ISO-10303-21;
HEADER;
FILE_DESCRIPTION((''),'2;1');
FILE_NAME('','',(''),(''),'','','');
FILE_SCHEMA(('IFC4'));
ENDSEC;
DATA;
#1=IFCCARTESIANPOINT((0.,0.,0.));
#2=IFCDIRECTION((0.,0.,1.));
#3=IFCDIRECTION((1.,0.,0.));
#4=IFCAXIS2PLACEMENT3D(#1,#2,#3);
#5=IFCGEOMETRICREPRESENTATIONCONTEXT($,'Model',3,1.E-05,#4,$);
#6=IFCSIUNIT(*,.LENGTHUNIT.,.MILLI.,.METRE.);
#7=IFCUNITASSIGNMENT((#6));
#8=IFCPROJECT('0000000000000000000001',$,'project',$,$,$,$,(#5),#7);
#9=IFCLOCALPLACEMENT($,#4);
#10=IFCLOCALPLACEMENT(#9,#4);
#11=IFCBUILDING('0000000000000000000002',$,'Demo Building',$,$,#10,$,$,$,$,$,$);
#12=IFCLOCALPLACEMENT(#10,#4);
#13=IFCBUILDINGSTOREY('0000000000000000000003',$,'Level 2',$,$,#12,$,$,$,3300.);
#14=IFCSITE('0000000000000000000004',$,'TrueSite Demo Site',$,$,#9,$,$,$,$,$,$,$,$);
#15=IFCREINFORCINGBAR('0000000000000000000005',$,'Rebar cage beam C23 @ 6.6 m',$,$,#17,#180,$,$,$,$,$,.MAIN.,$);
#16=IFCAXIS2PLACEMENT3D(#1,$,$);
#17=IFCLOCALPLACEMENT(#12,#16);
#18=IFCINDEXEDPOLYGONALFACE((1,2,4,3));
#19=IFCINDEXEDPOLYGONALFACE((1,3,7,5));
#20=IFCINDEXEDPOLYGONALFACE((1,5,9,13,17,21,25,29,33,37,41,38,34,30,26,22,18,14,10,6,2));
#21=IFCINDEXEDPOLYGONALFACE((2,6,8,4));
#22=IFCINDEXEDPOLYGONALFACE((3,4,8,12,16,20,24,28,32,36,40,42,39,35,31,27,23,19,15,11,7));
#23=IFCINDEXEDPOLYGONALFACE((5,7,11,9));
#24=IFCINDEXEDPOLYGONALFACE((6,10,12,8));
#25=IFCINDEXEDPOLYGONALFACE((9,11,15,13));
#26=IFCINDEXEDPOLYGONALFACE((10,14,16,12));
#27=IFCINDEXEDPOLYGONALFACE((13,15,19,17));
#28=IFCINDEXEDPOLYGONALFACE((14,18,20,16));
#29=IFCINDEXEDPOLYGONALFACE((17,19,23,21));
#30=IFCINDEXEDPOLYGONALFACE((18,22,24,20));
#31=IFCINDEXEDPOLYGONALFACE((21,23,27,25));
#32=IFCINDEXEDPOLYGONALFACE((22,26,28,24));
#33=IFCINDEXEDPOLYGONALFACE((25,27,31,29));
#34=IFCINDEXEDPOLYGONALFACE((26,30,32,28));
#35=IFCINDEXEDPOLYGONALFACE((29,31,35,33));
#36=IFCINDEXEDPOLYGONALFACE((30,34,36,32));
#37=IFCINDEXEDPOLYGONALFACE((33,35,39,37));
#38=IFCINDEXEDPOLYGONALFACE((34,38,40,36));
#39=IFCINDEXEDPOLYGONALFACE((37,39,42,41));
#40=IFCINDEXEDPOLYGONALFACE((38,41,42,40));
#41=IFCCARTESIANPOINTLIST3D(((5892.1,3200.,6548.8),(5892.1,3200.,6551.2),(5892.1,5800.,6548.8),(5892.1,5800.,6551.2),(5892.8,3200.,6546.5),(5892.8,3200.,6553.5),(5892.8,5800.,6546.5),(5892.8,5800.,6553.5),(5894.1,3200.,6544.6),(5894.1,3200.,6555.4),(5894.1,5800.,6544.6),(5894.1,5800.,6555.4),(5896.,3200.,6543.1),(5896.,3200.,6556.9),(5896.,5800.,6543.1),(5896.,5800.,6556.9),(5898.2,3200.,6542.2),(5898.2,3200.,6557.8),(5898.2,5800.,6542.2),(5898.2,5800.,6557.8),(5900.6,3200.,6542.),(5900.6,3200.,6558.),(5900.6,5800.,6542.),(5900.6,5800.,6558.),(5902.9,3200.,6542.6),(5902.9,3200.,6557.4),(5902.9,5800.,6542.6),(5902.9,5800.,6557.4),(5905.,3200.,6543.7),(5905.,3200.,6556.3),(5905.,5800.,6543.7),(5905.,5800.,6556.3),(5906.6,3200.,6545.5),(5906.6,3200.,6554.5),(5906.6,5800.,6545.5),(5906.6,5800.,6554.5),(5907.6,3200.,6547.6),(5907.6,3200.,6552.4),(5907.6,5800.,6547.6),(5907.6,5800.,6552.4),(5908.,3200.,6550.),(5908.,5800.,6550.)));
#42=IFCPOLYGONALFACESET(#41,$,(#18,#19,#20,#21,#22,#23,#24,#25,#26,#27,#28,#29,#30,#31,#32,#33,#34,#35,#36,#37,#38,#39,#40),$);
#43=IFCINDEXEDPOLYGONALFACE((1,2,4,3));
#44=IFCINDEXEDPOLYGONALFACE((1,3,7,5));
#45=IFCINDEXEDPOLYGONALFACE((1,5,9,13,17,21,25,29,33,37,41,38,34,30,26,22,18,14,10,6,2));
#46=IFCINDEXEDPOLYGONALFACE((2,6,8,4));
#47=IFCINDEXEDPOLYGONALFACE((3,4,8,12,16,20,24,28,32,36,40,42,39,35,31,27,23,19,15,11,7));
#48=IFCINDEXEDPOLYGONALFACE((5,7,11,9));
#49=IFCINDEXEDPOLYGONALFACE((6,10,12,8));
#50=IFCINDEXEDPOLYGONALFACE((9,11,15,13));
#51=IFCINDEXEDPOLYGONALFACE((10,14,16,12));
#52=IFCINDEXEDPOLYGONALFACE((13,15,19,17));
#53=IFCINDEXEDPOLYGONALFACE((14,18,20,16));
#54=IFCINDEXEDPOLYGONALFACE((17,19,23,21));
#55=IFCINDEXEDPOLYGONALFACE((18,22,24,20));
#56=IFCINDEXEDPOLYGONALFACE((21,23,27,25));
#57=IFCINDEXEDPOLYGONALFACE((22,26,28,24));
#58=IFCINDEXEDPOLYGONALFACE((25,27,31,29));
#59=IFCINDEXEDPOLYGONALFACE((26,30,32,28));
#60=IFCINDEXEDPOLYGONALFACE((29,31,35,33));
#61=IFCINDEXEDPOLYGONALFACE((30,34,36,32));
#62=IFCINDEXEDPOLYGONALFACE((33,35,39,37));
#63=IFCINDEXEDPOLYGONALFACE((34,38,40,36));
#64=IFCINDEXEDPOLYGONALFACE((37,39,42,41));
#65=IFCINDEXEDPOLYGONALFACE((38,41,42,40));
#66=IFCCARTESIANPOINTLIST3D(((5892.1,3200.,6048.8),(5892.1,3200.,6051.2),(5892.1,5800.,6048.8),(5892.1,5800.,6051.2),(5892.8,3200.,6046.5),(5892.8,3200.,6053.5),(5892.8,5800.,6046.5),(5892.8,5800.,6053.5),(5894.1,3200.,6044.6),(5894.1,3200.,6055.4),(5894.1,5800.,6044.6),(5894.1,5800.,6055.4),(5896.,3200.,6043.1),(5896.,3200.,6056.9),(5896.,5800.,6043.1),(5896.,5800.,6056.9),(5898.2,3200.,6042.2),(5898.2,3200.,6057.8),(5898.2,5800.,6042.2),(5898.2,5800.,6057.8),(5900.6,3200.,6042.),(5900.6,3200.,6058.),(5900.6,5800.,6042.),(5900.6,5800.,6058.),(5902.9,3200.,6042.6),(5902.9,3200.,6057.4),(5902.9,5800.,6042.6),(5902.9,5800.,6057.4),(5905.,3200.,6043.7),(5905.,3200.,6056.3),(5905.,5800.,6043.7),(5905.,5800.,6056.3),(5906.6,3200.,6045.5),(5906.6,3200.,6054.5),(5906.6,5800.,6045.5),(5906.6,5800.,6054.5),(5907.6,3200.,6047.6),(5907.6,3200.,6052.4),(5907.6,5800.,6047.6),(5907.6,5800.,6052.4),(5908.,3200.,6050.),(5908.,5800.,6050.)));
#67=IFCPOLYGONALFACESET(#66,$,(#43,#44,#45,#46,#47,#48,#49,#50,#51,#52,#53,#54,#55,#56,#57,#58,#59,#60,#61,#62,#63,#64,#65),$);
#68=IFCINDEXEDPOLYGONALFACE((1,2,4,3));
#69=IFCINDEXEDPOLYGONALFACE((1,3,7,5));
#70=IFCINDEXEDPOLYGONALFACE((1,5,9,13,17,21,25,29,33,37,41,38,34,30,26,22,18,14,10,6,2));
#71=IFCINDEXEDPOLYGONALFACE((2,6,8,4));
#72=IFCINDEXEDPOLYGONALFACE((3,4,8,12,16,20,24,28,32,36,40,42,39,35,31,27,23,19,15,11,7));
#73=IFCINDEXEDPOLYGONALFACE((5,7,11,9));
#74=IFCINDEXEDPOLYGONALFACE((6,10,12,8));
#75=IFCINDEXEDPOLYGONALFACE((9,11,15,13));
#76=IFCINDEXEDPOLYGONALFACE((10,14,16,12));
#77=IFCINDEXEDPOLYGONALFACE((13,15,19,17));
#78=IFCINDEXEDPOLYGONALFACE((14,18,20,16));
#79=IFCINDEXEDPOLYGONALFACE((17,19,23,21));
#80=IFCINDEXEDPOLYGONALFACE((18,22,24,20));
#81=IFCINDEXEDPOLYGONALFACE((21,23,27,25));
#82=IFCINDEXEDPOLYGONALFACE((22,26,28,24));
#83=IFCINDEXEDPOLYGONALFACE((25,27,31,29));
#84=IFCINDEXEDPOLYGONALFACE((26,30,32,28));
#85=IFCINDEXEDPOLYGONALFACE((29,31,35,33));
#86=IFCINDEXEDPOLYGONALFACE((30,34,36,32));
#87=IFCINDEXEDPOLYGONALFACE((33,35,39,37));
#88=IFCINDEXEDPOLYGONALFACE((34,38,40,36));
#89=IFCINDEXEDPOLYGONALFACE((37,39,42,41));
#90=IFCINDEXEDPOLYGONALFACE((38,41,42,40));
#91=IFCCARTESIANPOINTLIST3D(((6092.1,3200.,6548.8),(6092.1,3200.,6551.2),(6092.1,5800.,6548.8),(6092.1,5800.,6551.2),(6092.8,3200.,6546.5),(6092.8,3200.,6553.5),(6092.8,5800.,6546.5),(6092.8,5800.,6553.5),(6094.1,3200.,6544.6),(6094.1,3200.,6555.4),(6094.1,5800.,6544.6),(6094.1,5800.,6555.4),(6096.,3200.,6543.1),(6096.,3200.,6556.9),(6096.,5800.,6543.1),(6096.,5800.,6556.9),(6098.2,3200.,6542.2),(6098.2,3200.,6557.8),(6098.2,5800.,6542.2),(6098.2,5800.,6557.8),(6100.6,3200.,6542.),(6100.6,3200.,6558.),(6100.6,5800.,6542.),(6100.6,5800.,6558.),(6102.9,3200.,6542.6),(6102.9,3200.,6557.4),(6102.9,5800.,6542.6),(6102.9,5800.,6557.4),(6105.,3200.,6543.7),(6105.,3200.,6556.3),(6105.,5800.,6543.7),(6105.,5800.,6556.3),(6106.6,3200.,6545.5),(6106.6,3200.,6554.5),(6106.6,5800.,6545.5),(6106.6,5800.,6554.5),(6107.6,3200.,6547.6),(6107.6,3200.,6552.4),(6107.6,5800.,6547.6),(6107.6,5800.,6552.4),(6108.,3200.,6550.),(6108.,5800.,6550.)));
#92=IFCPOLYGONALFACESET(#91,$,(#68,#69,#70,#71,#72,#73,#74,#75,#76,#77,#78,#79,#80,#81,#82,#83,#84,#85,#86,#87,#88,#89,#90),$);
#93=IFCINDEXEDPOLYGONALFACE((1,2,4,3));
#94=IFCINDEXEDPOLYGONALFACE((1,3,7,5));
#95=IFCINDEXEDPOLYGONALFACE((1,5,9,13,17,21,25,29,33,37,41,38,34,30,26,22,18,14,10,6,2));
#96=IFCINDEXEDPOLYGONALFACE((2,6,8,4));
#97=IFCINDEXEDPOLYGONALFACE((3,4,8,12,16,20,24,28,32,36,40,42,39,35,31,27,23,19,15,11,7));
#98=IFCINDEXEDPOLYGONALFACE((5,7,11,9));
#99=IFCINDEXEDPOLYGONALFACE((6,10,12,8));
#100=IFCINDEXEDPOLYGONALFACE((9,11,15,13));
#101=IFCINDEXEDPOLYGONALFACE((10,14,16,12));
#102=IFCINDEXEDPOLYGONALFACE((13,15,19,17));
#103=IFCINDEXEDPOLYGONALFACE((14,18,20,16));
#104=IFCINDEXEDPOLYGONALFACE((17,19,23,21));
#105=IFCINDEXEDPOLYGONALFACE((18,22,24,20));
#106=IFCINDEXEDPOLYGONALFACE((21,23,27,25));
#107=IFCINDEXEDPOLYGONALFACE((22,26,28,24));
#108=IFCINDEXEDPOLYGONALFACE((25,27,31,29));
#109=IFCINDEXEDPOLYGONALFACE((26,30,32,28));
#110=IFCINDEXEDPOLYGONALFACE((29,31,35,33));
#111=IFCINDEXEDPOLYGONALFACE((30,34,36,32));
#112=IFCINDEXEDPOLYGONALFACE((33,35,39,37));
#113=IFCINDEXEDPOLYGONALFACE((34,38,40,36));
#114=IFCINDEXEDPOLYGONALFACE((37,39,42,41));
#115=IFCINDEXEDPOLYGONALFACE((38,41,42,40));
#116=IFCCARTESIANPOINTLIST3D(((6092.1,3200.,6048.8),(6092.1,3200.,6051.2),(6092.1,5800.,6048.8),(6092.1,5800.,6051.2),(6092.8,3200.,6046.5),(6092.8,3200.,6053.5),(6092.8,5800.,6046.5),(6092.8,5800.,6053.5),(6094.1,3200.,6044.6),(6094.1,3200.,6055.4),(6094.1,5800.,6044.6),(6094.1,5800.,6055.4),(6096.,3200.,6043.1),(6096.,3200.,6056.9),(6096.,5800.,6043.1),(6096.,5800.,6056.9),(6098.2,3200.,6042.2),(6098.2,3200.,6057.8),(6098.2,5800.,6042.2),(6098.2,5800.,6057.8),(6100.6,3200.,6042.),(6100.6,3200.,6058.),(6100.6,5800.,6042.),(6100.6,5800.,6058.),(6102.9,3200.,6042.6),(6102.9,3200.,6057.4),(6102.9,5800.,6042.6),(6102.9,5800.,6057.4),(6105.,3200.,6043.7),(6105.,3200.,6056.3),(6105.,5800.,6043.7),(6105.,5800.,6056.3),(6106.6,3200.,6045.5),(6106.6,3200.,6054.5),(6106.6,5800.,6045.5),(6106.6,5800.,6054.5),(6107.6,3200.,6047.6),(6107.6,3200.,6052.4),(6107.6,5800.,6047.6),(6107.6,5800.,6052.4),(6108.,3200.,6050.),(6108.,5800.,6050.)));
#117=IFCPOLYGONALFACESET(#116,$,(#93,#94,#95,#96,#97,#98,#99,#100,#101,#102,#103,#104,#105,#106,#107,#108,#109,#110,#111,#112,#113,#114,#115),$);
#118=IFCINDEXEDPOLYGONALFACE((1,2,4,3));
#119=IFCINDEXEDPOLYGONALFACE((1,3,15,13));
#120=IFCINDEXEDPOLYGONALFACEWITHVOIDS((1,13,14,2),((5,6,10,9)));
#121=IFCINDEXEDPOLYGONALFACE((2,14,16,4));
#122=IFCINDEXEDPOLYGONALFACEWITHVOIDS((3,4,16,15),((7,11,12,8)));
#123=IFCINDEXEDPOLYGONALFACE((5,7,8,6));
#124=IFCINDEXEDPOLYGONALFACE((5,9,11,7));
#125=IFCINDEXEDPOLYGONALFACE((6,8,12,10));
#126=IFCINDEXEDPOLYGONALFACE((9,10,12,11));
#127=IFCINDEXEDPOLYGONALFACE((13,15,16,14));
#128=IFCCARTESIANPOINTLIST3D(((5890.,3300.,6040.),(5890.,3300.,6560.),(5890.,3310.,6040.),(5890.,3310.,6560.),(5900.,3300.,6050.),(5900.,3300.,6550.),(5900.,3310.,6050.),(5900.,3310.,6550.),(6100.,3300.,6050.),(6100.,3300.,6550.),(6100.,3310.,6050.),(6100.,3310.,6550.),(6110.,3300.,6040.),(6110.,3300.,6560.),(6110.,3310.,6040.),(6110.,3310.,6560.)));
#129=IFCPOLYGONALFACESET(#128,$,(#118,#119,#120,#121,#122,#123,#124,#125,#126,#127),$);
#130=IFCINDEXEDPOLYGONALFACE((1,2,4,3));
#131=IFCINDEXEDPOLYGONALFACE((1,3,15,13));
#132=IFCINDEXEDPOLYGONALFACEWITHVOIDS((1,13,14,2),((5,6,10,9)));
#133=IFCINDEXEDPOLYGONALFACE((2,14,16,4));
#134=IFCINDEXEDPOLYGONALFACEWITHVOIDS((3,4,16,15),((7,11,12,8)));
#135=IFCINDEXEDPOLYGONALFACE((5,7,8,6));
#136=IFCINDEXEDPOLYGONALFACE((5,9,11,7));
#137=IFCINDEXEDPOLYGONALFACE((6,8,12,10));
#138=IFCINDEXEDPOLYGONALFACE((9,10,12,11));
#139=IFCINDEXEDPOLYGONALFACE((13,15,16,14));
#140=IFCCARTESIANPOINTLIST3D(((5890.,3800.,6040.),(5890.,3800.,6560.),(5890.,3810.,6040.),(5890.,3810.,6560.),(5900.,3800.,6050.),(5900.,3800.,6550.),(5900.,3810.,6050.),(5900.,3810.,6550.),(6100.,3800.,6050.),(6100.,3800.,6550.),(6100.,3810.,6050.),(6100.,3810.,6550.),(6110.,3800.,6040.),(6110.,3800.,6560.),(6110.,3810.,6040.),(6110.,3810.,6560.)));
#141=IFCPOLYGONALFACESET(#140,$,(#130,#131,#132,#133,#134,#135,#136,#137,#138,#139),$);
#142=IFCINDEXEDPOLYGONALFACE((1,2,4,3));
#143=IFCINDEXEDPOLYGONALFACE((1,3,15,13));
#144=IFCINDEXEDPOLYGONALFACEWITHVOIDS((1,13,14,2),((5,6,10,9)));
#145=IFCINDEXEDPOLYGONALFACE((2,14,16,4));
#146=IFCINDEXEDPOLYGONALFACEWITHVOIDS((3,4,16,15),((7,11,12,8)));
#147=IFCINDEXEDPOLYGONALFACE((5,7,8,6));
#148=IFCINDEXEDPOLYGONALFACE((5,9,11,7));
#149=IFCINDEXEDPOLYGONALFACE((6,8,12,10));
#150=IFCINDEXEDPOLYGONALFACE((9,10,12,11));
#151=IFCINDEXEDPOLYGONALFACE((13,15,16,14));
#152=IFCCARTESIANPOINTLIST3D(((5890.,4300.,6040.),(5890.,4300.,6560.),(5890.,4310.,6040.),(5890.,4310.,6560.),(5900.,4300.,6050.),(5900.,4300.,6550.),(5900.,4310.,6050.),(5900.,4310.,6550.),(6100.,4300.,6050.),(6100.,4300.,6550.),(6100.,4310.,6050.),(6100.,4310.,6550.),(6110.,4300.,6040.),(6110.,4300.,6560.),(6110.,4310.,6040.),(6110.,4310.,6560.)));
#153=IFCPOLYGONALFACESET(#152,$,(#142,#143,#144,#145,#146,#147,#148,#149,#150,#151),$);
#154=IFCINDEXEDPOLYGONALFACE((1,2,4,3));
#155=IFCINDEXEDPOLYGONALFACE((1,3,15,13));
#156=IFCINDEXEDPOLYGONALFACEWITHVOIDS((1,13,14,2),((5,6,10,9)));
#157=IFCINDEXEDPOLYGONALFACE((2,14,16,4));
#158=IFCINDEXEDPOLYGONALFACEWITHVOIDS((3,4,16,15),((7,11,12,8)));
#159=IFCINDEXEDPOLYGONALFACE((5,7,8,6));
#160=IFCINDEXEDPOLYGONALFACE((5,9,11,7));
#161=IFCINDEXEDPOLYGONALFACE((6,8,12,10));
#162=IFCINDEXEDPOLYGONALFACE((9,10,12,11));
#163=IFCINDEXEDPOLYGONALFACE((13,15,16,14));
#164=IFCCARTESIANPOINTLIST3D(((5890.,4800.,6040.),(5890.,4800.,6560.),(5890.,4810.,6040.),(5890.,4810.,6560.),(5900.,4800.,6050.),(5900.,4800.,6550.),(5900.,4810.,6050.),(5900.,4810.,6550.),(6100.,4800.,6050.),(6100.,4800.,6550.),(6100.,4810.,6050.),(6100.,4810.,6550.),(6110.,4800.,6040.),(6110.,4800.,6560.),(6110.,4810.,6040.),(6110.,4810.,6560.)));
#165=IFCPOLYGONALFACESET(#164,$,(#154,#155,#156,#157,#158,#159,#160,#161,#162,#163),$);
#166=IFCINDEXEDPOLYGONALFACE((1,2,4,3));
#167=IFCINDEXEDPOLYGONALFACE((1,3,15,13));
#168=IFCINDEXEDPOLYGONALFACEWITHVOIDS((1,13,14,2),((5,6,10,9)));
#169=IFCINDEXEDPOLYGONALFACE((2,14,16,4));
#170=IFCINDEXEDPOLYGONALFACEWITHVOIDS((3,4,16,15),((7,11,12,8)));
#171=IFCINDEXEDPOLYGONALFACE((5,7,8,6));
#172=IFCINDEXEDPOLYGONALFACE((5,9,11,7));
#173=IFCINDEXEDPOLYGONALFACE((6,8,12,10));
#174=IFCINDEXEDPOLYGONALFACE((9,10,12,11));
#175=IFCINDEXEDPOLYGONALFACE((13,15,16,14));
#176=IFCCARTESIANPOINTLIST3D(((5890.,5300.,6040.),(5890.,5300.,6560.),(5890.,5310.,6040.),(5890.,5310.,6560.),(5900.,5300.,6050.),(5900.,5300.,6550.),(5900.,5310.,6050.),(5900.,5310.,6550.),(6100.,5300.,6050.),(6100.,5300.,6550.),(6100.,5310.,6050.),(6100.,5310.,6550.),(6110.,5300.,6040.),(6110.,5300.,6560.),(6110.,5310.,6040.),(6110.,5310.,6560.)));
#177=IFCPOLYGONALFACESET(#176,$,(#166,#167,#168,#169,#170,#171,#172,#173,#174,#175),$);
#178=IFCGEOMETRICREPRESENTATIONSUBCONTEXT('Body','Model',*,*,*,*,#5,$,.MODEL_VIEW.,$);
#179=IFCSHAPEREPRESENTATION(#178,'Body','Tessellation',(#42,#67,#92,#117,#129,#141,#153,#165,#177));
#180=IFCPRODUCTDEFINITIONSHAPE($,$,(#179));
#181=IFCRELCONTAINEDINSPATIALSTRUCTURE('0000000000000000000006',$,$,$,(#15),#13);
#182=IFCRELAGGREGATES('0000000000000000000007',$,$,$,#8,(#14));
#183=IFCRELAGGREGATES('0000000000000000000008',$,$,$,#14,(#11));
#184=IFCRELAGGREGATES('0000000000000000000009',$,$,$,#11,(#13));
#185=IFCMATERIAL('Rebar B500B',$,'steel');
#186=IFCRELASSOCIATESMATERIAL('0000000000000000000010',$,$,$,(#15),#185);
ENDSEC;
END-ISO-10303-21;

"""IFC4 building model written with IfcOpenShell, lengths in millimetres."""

from ifc_helpers import new_model, si_unit, frame, origin_with_axes, place, context, subcontext, project, spatial, hollow_rectangle, circle, extrude, material, element, save


model = new_model("IFC4")

# Units and contexts
model_context = context("Model", 3, precision=1e-05, world=origin_with_axes())
body_context = subcontext(model_context, "Body", "Model", "MODEL_VIEW")
ifc_project = project(units=[si_unit("LENGTHUNIT", "METRE", prefix="MILLI")], contexts=[model_context])

# Site, building, storey
site_placement = place(None, origin_with_axes())
site = spatial("IfcSite", under=ifc_project, at=site_placement, Name="TrueSite Demo Site")
building_placement = place(site_placement, origin_with_axes())
building = spatial("IfcBuilding", under=site, at=building_placement, Name="Demo Building")
storey_placement = place(building_placement, origin_with_axes())
storey = spatial("IfcBuildingStorey", under=building, at=storey_placement, Name="Level 2", Elevation=3300.0)

# Reinforcing bar
ifc_material_1 = material(Name="Rebar B500B", Category="steel")
for number, where, z_axis, x_axis, name in (
    (1, (6000.0, 3200.0, 6300.0), (0.0, 1.0, 0.0), (1.0, 0.0, 0.0), "Rebar cage beam C23 @ 6.6 m"),
):
    element("IfcReinforcingBar", number, at=place(storey_placement, frame(where, z_axis=z_axis, x_axis=x_axis)), inside=storey, material=ifc_material_1, Name=name, PredefinedType="MAIN", context=body_context, shape_type="SweptSolid", body=[
        extrude(circle(Radius=8.0), frame((-100.0, -250.0, 0.0)), (0.0, 0.0, 1.0), 2600.0),
        extrude(circle(Radius=8.0), frame((-100.0, 250.0, 0.0)), (0.0, 0.0, 1.0), 2600.0),
        extrude(circle(Radius=8.0), frame((100.0, -250.0, 0.0)), (0.0, 0.0, 1.0), 2600.0),
        extrude(circle(Radius=8.0), frame((100.0, 250.0, 0.0)), (0.0, 0.0, 1.0), 2600.0),
        extrude(hollow_rectangle(XDim=220.0, YDim=520.0, WallThickness=10.0), frame((0.0, 0.0, 100.0)), (0.0, 0.0, 1.0), 10.0),
        extrude(hollow_rectangle(XDim=220.0, YDim=520.0, WallThickness=10.0), frame((0.0, 0.0, 600.0)), (0.0, 0.0, 1.0), 10.0),
        extrude(hollow_rectangle(XDim=220.0, YDim=520.0, WallThickness=10.0), frame((0.0, 0.0, 1100.0)), (0.0, 0.0, 1.0), 10.0),
        extrude(hollow_rectangle(XDim=220.0, YDim=520.0, WallThickness=10.0), frame((0.0, 0.0, 1600.0)), (0.0, 0.0, 1.0), 10.0),
        extrude(hollow_rectangle(XDim=220.0, YDim=520.0, WallThickness=10.0), frame((0.0, 0.0, 2100.0)), (0.0, 0.0, 1.0), 10.0),
    ])

save(model, "model.ifc")
